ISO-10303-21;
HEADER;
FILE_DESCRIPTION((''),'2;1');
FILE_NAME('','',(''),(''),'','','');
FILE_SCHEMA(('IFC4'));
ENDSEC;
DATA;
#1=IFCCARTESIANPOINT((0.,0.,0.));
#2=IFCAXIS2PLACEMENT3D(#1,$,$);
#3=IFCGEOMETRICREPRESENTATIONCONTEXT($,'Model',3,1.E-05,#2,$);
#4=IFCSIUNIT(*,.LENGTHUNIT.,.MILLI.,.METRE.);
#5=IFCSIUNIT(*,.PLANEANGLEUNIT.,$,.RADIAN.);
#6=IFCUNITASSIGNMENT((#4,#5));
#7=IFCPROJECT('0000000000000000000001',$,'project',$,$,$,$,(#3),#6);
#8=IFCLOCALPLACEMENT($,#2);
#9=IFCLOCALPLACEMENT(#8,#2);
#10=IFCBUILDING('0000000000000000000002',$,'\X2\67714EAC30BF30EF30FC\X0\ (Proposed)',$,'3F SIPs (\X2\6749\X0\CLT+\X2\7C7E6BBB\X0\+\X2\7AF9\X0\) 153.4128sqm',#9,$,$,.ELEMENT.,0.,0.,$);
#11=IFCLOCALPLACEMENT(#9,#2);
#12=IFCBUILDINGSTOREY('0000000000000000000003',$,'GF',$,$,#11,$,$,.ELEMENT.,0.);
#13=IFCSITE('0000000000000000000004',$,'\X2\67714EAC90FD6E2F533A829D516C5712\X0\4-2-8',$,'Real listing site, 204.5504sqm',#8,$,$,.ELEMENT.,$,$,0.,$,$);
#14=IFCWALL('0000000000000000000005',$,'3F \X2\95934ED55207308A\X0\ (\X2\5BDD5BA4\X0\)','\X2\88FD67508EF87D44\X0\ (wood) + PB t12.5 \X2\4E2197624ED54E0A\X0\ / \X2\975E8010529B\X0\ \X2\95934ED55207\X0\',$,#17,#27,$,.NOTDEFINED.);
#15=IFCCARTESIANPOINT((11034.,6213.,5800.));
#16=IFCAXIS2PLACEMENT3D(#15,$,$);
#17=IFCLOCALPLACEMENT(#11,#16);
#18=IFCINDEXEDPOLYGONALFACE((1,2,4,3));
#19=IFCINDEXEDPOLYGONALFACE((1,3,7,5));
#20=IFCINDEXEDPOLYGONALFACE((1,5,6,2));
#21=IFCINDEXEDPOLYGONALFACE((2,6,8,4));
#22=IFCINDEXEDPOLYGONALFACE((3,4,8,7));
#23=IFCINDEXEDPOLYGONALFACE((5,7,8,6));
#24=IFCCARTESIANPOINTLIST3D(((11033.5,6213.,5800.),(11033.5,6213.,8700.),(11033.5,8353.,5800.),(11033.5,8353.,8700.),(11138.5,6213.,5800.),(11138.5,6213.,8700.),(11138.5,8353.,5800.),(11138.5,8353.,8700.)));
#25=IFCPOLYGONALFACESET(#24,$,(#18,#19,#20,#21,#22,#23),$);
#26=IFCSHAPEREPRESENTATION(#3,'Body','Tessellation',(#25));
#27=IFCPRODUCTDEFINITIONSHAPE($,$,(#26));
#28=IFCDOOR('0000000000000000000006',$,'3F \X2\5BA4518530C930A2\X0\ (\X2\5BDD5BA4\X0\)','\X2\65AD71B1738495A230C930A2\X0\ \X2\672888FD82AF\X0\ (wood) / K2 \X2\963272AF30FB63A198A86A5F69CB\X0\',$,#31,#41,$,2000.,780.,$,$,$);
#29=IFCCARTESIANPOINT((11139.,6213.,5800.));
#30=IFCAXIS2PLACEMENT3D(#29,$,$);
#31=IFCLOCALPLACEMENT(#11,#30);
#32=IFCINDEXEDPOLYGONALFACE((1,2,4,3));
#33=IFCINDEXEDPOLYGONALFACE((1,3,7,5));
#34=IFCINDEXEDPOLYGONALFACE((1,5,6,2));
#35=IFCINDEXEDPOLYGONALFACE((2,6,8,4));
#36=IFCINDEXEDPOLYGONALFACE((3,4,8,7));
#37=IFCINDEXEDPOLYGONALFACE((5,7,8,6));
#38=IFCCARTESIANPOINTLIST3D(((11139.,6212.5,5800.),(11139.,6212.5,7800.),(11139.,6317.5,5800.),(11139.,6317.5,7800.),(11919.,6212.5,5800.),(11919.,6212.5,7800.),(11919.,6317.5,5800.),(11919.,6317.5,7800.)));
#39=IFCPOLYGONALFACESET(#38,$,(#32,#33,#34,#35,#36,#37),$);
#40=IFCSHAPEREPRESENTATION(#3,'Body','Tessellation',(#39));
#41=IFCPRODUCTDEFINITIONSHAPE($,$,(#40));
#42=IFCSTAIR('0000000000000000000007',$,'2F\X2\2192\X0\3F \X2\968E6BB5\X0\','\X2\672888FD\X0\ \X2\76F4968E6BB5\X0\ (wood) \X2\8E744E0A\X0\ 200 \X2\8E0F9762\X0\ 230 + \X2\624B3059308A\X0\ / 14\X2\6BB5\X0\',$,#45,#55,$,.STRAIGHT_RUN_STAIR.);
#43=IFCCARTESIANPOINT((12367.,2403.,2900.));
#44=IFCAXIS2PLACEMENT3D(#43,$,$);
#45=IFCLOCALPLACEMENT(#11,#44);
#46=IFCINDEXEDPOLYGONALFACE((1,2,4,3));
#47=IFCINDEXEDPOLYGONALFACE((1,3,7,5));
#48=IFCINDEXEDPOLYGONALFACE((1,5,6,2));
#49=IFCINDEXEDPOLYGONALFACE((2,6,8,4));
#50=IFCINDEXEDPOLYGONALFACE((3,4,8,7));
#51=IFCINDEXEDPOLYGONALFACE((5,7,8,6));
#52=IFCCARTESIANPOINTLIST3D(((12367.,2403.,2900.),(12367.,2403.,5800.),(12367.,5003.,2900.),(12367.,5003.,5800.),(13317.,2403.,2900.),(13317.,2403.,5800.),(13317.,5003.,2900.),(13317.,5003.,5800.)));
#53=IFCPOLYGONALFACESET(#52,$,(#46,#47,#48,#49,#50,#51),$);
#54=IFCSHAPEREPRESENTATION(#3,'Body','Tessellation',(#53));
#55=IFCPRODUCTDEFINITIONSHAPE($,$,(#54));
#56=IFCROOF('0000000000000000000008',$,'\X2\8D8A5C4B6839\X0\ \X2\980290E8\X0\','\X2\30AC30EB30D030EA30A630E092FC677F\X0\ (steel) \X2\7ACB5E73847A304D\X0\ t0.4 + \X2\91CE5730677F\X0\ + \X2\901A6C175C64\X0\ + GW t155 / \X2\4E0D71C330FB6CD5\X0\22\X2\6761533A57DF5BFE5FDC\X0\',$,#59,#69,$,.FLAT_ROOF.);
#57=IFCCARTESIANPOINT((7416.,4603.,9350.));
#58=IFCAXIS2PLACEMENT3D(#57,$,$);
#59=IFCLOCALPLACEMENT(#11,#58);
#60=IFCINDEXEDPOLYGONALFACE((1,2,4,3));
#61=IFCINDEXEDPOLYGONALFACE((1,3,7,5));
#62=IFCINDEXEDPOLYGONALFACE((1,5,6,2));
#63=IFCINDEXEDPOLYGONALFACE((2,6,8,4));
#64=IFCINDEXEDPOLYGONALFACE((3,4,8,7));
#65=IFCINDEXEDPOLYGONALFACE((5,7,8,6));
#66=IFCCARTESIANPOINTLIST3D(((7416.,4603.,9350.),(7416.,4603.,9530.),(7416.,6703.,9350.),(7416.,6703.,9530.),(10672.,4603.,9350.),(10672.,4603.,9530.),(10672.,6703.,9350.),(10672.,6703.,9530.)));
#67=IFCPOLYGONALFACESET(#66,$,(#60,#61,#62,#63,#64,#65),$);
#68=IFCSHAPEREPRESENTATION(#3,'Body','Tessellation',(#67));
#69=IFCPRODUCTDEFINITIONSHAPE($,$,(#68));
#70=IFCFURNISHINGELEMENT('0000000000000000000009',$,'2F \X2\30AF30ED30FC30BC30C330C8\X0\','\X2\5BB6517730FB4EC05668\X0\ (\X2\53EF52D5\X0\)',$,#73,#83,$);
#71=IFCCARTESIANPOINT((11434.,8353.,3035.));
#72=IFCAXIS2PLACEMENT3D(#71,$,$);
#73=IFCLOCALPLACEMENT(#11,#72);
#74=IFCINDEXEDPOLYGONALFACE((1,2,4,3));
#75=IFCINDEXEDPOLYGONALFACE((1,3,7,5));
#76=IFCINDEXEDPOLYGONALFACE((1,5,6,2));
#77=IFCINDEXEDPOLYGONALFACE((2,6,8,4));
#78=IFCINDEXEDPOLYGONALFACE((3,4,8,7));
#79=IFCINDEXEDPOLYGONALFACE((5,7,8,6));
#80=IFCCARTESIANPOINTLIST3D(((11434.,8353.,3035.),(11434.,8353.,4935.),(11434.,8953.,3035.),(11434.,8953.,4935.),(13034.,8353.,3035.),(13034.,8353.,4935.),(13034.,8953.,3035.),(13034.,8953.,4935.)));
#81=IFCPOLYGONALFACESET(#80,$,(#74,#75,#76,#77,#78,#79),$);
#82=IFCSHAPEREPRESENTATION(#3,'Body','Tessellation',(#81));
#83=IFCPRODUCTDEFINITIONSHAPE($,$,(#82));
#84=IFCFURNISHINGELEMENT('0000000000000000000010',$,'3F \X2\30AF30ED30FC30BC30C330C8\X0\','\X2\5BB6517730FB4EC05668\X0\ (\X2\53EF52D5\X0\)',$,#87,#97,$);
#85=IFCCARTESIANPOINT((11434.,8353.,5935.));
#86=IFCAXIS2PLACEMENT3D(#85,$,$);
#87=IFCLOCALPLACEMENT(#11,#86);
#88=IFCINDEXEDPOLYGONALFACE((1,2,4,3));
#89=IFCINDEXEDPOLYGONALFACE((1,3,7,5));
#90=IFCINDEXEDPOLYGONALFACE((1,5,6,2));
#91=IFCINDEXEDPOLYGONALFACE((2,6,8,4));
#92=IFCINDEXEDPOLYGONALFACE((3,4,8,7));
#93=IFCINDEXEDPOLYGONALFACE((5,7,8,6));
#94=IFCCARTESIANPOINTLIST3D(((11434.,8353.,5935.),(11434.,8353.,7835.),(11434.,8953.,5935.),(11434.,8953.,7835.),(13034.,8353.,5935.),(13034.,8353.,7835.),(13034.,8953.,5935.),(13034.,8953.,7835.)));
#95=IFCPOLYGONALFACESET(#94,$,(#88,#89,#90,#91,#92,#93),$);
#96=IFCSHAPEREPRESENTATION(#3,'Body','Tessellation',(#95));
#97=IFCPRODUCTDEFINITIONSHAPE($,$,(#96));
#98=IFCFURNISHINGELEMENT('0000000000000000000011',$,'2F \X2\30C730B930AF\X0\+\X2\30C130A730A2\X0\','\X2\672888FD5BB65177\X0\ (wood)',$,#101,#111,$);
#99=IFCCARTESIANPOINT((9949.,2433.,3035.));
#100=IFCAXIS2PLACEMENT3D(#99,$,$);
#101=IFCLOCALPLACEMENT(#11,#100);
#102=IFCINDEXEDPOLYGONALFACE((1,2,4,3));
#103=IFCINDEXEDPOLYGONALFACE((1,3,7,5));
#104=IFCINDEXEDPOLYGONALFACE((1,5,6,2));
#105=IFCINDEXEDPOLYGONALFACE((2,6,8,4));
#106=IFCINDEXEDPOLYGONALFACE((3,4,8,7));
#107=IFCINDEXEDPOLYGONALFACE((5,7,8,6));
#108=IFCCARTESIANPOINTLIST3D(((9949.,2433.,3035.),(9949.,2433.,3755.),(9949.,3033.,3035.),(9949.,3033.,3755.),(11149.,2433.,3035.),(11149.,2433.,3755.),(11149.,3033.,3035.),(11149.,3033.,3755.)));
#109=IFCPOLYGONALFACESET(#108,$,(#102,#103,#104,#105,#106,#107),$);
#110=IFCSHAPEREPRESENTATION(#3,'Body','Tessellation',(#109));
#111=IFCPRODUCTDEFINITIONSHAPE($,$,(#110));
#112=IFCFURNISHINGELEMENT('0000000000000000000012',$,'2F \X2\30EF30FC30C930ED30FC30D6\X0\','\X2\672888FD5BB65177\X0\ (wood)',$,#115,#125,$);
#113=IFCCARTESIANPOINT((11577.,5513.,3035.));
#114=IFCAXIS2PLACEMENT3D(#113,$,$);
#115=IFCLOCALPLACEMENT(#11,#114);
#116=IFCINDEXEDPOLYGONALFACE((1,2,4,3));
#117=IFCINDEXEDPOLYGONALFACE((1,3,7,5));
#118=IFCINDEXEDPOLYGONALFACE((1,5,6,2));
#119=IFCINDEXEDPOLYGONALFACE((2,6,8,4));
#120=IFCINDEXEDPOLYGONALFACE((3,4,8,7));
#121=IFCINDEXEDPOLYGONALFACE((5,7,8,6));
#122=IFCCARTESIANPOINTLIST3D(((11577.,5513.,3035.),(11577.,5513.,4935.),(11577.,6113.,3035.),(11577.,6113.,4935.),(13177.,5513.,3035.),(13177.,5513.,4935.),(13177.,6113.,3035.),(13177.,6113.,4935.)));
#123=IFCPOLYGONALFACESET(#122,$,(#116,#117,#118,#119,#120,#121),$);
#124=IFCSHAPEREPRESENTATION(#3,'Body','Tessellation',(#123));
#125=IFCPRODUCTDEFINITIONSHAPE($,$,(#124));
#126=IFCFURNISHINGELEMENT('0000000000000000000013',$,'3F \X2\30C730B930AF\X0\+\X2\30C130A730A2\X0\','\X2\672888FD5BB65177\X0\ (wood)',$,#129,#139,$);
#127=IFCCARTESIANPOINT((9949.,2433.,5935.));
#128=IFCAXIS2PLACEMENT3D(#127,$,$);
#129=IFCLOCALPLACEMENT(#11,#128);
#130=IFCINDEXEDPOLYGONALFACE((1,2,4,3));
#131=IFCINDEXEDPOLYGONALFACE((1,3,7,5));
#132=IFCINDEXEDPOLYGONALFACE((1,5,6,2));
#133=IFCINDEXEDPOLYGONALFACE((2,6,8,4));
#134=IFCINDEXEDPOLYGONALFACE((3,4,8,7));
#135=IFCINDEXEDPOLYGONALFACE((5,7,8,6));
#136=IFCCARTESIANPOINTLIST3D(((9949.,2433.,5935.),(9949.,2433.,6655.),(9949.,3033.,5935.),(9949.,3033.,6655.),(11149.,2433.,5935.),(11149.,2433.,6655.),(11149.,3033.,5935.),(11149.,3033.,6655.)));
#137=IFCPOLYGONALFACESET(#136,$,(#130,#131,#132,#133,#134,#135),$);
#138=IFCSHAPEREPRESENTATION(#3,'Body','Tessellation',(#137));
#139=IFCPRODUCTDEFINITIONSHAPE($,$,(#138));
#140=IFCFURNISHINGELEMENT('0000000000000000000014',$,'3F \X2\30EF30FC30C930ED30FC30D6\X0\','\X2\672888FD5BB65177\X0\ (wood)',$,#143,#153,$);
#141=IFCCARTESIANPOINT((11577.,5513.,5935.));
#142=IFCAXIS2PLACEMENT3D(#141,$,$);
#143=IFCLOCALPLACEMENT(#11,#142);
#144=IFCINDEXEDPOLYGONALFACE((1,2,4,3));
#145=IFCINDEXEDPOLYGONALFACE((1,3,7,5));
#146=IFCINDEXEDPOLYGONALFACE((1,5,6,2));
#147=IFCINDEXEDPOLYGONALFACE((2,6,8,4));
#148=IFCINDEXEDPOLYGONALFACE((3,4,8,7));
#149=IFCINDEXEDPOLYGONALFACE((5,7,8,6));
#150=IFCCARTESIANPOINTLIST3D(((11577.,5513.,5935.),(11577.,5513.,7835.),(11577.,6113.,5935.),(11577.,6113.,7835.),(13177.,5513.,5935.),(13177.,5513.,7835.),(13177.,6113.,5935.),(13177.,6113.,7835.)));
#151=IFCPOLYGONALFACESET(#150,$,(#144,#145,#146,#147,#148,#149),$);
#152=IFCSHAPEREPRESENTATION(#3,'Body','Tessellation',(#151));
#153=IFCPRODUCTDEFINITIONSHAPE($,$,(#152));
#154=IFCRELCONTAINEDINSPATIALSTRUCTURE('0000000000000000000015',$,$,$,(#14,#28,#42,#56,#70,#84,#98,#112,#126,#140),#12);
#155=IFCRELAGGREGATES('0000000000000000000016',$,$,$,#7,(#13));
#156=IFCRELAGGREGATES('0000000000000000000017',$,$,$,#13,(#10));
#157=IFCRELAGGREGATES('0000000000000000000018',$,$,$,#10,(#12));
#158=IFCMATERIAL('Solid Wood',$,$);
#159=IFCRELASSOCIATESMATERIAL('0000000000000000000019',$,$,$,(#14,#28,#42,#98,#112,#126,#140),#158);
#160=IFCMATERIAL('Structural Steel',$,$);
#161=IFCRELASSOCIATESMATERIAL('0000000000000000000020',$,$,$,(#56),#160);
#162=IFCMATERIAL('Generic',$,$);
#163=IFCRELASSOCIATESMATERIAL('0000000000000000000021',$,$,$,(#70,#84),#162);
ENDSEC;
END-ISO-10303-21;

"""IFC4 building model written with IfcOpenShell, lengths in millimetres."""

from ifc_helpers import new_model, si_unit, frame, frame_2d, origin, place, context, project, spatial, rectangle, extrude, material, element, save


model = new_model("IFC4")

# Units and contexts
model_context = context("Model", 3, precision=1e-05, world=origin())
ifc_project = project(units=[si_unit("LENGTHUNIT", "METRE", prefix="MILLI"), si_unit("PLANEANGLEUNIT", "RADIAN")], contexts=[model_context])

# Site, building, storey
site_placement = place(None, origin())
site = spatial("IfcSite", under=ifc_project, at=site_placement, Name="東京都港区芝公園4-2-8", ObjectType="Real listing site, 204.5504sqm", CompositionType="ELEMENT", RefElevation=0.0)
building_placement = place(site_placement, origin())
building = spatial("IfcBuilding", under=site, at=building_placement, Name="東京タワー (Proposed)", ObjectType="3F SIPs (杉CLT+籾殻+竹) 153.4128sqm", CompositionType="ELEMENT", ElevationOfRefHeight=0.0, ElevationOfTerrain=0.0)
storey_placement = place(building_placement, origin())
storey = spatial("IfcBuildingStorey", under=building, at=storey_placement, Name="GF", CompositionType="ELEMENT", Elevation=0.0)

# Shared definitions
ifc_material_1 = material(Name="Solid Wood")

# Wall
wall_1_placement = place(storey_placement, frame((11034.0, 6213.0, 5800.0)))
element("IfcWall", 1, at=wall_1_placement, inside=storey, material=ifc_material_1, Name="3F 間仕切り (寝室)", Description="製材軸組 (wood) + PB t12.5 両面仕上 / 非耐力 間仕切", PredefinedType="NOTDEFINED", context=model_context, shape_type="SweptSolid", body=[
    extrude(rectangle(XDim=105.0, YDim=2140.0, at=frame_2d((52.0, 1070.0))), frame((11034.0, 6213.0, 5800.0)), (0.0, 0.0, 1.0), 2900.0),
])

# Door
door_1_placement = place(storey_placement, frame((11139.0, 6213.0, 5800.0)))
element("IfcDoor", 2, at=door_1_placement, inside=storey, material=ifc_material_1, Name="3F 室内ドア (寝室)", Description="断熱玄関ドア 木製芯 (wood) / K2 防犯・採風機構", OverallHeight=2000.0, OverallWidth=780.0, context=model_context, shape_type="SweptSolid", body=[
    extrude(rectangle(XDim=780.0, YDim=105.0, at=frame_2d((390.0, 52.0))), frame((11139.0, 6213.0, 5800.0)), (0.0, 0.0, 1.0), 2000.0),
])

# Stair
stair_placement = place(storey_placement, frame((12367.0, 2403.0, 2900.0)))
element("IfcStair", 3, at=stair_placement, inside=storey, material=ifc_material_1, Name="2F→3F 階段", Description="木製 直階段 (wood) 蹴上 200 踏面 230 + 手すり / 14段", PredefinedType="STRAIGHT_RUN_STAIR", context=model_context, shape_type="SweptSolid", body=[
    extrude(rectangle(XDim=950.0, YDim=2600.0, at=frame_2d((475.0, 1300.0))), frame((12367.0, 2403.0, 2900.0)), (0.0, 0.0, 1.0), 2900.0),
])

# Roof
ifc_material_2 = material(Name="Structural Steel")
roof_placement = place(storey_placement, frame((7416.0, 4603.0, 9350.0)))
element("IfcRoof", 4, at=roof_placement, inside=storey, material=ifc_material_2, Name="越屋根 頂部", Description="ガルバリウム鋼板 (steel) 立平葺き t0.4 + 野地板 + 通気層 + GW t155 / 不燃・法22条区域対応", PredefinedType="FLAT_ROOF", context=model_context, shape_type="SweptSolid", body=[
    extrude(rectangle(XDim=3256.0, YDim=2100.0, at=frame_2d((1628.0, 1050.0))), frame((7416.0, 4603.0, 9350.0)), (0.0, 0.0, 1.0), 180.0),
])

# Furnishing elements
ifc_material_3 = material(Name="Generic")
furnishing_1_placement = place(storey_placement, frame((11434.0, 8353.0, 3035.0)))
element("IfcFurnishingElement", 5, at=furnishing_1_placement, inside=storey, material=ifc_material_3, Name="2F クローゼット", Description="家具・什器 (可動)", context=model_context, shape_type="SweptSolid", body=[
    extrude(rectangle(XDim=1600.0, YDim=600.0, at=frame_2d((800.0, 300.0))), frame((11434.0, 8353.0, 3035.0)), (0.0, 0.0, 1.0), 1900.0),
])
furnishing_2_placement = place(storey_placement, frame((11434.0, 8353.0, 5935.0)))
element("IfcFurnishingElement", 6, at=furnishing_2_placement, inside=storey, material=ifc_material_3, Name="3F クローゼット", Description="家具・什器 (可動)", context=model_context, shape_type="SweptSolid", body=[
    extrude(rectangle(XDim=1600.0, YDim=600.0, at=frame_2d((800.0, 300.0))), frame((11434.0, 8353.0, 5935.0)), (0.0, 0.0, 1.0), 1900.0),
])
furnishing_3_placement = place(storey_placement, frame((9949.0, 2433.0, 3035.0)))
element("IfcFurnishingElement", 7, at=furnishing_3_placement, inside=storey, material=ifc_material_1, Name="2F デスク+チェア", Description="木製家具 (wood)", context=model_context, shape_type="SweptSolid", body=[
    extrude(rectangle(XDim=1200.0, YDim=600.0, at=frame_2d((600.0, 300.0))), frame((9949.0, 2433.0, 3035.0)), (0.0, 0.0, 1.0), 720.0),
])
furnishing_4_placement = place(storey_placement, frame((11577.0, 5513.0, 3035.0)))
element("IfcFurnishingElement", 8, at=furnishing_4_placement, inside=storey, material=ifc_material_1, Name="2F ワードローブ", Description="木製家具 (wood)", context=model_context, shape_type="SweptSolid", body=[
    extrude(rectangle(XDim=1600.0, YDim=600.0, at=frame_2d((800.0, 300.0))), frame((11577.0, 5513.0, 3035.0)), (0.0, 0.0, 1.0), 1900.0),
])
furnishing_5_placement = place(storey_placement, frame((9949.0, 2433.0, 5935.0)))
element("IfcFurnishingElement", 9, at=furnishing_5_placement, inside=storey, material=ifc_material_1, Name="3F デスク+チェア", Description="木製家具 (wood)", context=model_context, shape_type="SweptSolid", body=[
    extrude(rectangle(XDim=1200.0, YDim=600.0, at=frame_2d((600.0, 300.0))), frame((9949.0, 2433.0, 5935.0)), (0.0, 0.0, 1.0), 720.0),
])
furnishing_6_placement = place(storey_placement, frame((11577.0, 5513.0, 5935.0)))
element("IfcFurnishingElement", 10, at=furnishing_6_placement, inside=storey, material=ifc_material_1, Name="3F ワードローブ", Description="木製家具 (wood)", context=model_context, shape_type="SweptSolid", body=[
    extrude(rectangle(XDim=1600.0, YDim=600.0, at=frame_2d((800.0, 300.0))), frame((11577.0, 5513.0, 5935.0)), (0.0, 0.0, 1.0), 1900.0),
])

save(model, "model.ifc")
